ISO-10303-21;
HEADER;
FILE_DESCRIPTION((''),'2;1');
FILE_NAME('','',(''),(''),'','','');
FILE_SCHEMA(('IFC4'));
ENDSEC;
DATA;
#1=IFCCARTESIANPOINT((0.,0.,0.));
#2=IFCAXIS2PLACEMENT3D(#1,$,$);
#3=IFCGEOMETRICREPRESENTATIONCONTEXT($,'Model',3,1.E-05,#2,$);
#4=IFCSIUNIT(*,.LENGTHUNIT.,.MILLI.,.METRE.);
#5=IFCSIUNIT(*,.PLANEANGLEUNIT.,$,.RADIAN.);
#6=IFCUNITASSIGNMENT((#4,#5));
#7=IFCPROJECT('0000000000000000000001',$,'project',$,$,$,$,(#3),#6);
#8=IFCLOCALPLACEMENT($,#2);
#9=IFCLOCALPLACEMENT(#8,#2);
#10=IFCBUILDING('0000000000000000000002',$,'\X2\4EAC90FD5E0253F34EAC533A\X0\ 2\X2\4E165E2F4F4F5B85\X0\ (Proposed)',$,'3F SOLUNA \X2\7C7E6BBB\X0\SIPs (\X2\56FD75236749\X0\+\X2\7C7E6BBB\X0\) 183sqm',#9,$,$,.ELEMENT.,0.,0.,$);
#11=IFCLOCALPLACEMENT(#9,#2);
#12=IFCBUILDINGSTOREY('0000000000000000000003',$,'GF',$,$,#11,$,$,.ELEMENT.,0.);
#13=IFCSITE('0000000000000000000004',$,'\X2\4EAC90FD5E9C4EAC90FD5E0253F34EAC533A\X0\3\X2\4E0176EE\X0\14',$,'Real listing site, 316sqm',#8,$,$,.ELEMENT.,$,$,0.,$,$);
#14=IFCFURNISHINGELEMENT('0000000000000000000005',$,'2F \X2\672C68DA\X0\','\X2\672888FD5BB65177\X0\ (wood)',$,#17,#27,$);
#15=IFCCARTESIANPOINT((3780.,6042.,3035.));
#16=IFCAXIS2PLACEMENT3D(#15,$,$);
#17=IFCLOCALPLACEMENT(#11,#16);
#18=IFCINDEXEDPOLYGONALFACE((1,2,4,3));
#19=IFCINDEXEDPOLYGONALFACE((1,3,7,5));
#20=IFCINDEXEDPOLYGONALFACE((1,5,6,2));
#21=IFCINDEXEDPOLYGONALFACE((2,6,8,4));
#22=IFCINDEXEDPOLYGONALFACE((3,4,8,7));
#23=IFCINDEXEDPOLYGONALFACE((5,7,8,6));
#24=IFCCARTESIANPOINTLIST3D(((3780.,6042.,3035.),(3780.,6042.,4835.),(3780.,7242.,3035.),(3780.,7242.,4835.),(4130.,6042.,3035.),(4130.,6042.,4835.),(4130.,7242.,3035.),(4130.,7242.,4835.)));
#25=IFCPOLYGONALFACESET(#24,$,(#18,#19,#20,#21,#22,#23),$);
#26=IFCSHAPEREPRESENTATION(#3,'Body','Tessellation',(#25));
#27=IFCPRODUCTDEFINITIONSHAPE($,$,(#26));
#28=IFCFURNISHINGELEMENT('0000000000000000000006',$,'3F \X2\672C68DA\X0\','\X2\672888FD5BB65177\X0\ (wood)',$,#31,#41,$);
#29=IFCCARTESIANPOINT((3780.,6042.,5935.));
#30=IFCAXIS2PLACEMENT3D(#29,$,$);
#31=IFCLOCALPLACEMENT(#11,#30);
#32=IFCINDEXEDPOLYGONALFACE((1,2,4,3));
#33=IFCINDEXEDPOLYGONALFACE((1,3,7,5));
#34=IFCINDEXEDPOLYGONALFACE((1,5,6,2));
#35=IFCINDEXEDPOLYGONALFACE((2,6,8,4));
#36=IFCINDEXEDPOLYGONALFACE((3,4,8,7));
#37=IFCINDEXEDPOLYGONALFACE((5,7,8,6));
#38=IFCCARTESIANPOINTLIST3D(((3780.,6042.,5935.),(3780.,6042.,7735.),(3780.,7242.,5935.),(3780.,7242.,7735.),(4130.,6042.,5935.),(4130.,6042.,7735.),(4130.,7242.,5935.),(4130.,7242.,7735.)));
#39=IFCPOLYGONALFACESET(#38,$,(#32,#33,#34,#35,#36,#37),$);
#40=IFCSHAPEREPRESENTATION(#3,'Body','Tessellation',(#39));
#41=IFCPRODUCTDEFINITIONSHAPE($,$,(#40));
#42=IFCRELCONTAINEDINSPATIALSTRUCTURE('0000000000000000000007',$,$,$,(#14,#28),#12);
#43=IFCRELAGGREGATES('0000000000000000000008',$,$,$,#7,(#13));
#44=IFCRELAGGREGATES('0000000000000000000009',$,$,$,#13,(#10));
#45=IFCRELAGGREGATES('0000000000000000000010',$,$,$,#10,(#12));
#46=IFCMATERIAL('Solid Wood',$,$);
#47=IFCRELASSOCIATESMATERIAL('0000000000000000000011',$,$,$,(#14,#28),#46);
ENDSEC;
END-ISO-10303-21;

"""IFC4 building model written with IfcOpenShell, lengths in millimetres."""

from ifc_helpers import new_model, si_unit, frame, frame_2d, origin, place, context, project, spatial, rectangle, extrude, material, element, save


model = new_model("IFC4")

# Units and contexts
model_context = context("Model", 3, precision=1e-05, world=origin())
ifc_project = project(units=[si_unit("LENGTHUNIT", "METRE", prefix="MILLI"), si_unit("PLANEANGLEUNIT", "RADIAN")], contexts=[model_context])

# Site, building, storey
site_placement = place(None, origin())
site = spatial("IfcSite", under=ifc_project, at=site_placement, Name="京都府京都市右京区3丁目14", ObjectType="Real listing site, 316sqm", CompositionType="ELEMENT", RefElevation=0.0)
building_placement = place(site_placement, origin())
building = spatial("IfcBuilding", under=site, at=building_placement, Name="京都市右京区 2世帯住宅 (Proposed)", ObjectType="3F SOLUNA 籾殻SIPs (国産杉+籾殻) 183sqm", CompositionType="ELEMENT", ElevationOfRefHeight=0.0, ElevationOfTerrain=0.0)
storey_placement = place(building_placement, origin())
storey = spatial("IfcBuildingStorey", under=building, at=storey_placement, Name="GF", CompositionType="ELEMENT", Elevation=0.0)

# Shared definitions
ifc_material_1 = material(Name="Solid Wood")

# Furnishing elements
furnishing_1_placement = place(storey_placement, frame((3780.0, 6042.0, 3035.0)))
element("IfcFurnishingElement", 1, at=furnishing_1_placement, inside=storey, material=ifc_material_1, Name="2F 本棚", Description="木製家具 (wood)", context=model_context, shape_type="SweptSolid", body=[
    extrude(rectangle(XDim=350.0, YDim=1200.0, at=frame_2d((175.0, 600.0))), frame((3780.0, 6042.0, 3035.0)), (0.0, 0.0, 1.0), 1800.0),
])
furnishing_2_placement = place(storey_placement, frame((3780.0, 6042.0, 5935.0)))
element("IfcFurnishingElement", 2, at=furnishing_2_placement, inside=storey, material=ifc_material_1, Name="3F 本棚", Description="木製家具 (wood)", context=model_context, shape_type="SweptSolid", body=[
    extrude(rectangle(XDim=350.0, YDim=1200.0, at=frame_2d((175.0, 600.0))), frame((3780.0, 6042.0, 5935.0)), (0.0, 0.0, 1.0), 1800.0),
])

save(model, "model.ifc")
